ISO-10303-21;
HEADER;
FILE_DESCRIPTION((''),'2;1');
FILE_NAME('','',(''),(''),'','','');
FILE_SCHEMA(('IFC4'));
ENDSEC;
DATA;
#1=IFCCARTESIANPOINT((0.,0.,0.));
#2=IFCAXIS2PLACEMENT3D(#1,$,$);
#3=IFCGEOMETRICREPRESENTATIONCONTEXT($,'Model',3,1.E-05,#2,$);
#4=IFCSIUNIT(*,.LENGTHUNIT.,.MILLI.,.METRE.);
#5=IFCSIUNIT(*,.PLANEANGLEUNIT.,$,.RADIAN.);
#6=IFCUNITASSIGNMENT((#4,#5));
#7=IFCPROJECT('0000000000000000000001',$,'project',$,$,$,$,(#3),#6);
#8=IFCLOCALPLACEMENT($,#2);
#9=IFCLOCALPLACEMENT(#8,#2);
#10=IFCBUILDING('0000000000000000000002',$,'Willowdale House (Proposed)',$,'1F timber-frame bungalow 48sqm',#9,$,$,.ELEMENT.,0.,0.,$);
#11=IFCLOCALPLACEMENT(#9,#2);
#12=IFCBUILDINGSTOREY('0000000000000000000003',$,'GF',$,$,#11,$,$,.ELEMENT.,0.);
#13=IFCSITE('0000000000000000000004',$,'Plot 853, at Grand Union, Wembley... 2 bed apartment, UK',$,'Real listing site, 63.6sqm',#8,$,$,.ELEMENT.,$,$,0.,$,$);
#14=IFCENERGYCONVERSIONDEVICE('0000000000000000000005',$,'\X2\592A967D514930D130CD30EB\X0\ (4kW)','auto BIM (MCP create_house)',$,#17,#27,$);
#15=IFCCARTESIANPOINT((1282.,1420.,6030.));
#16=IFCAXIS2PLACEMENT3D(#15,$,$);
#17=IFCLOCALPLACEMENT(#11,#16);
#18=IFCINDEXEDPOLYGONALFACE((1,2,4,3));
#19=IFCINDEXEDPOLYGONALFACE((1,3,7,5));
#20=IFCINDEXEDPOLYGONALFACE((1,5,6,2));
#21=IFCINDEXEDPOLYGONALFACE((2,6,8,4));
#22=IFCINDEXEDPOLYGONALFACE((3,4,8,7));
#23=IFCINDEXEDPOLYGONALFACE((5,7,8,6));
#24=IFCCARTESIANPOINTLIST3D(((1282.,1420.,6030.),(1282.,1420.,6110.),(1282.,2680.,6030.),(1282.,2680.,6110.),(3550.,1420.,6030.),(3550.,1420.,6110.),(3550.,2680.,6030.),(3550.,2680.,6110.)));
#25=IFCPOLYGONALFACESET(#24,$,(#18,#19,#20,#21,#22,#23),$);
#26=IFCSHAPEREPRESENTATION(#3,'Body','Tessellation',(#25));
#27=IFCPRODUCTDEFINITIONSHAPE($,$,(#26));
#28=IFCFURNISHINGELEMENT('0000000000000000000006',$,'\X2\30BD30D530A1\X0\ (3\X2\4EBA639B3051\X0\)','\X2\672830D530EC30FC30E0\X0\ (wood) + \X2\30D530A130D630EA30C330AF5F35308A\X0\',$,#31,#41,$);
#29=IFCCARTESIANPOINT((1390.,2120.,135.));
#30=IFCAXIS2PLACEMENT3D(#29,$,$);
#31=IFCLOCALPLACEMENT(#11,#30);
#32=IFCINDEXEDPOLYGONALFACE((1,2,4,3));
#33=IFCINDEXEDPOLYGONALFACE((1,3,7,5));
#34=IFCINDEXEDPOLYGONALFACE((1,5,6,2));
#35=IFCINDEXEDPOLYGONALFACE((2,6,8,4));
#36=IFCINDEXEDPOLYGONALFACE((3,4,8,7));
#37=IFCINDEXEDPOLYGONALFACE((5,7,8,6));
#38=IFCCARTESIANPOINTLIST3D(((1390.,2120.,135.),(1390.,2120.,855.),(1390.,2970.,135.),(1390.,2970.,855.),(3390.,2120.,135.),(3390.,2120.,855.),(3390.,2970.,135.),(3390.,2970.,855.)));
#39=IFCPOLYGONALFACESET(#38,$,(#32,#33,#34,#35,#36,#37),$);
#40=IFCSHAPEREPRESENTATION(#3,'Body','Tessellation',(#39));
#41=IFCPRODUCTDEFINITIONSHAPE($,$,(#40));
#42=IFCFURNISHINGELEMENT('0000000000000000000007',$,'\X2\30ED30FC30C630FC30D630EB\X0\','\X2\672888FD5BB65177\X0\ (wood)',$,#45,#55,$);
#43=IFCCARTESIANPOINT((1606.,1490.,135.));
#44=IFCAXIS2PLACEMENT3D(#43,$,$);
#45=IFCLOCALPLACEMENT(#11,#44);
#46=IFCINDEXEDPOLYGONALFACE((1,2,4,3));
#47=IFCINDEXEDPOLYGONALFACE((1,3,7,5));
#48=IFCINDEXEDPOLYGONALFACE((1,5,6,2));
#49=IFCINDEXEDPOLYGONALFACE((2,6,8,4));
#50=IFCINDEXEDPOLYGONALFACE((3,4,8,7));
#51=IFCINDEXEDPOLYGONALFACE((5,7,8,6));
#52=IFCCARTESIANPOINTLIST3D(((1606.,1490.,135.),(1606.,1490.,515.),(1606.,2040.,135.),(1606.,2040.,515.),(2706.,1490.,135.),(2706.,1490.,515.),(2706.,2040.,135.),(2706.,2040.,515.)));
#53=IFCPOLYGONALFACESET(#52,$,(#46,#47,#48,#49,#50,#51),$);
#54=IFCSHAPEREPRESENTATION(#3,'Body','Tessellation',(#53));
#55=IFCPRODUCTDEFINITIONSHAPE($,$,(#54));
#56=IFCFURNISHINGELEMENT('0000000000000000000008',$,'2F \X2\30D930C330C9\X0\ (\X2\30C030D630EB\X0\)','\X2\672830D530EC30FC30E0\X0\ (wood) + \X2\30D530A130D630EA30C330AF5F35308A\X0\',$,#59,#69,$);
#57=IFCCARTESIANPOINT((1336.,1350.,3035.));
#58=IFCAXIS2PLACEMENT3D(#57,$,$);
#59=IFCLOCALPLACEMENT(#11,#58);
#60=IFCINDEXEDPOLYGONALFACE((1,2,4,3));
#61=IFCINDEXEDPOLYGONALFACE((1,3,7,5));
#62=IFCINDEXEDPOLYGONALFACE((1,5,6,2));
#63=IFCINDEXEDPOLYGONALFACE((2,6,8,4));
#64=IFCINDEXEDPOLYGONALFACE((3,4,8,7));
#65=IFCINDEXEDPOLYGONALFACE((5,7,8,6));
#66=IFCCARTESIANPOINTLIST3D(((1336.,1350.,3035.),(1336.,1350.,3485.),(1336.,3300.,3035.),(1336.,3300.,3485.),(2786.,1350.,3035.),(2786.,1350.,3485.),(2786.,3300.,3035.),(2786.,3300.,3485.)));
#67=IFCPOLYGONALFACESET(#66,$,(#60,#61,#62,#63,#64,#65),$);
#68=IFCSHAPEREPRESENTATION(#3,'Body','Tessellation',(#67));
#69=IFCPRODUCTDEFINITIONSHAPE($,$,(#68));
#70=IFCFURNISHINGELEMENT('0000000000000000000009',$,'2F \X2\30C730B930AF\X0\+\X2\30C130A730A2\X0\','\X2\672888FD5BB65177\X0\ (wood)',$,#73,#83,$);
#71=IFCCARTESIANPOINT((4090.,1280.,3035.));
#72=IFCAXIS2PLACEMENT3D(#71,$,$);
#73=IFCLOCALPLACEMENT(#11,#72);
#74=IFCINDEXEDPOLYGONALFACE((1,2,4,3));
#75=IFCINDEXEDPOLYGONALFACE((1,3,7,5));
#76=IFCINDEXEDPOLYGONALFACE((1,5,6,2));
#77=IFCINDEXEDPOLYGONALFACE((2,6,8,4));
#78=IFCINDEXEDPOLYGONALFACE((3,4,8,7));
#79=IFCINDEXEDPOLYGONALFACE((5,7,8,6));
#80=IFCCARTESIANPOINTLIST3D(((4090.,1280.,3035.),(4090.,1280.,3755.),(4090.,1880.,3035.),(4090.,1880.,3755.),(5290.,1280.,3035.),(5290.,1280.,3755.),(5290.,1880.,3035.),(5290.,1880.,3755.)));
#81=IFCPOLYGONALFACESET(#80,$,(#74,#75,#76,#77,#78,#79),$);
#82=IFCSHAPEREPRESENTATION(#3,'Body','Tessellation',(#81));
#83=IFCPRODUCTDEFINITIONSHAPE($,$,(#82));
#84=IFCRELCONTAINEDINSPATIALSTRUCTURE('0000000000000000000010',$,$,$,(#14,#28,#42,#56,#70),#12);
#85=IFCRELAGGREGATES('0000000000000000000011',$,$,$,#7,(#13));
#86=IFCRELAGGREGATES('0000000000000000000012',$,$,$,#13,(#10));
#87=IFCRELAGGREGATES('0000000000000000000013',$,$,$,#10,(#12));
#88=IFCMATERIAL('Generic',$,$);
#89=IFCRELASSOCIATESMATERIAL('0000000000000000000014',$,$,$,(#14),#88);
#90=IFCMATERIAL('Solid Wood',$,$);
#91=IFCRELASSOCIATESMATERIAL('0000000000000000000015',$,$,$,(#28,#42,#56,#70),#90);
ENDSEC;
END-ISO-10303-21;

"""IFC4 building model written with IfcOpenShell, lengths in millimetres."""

from ifc_helpers import new_model, si_unit, frame, frame_2d, origin, place, context, project, spatial, rectangle, extrude, material, element, save


model = new_model("IFC4")

# Units and contexts
model_context = context("Model", 3, precision=1e-05, world=origin())
ifc_project = project(units=[si_unit("LENGTHUNIT", "METRE", prefix="MILLI"), si_unit("PLANEANGLEUNIT", "RADIAN")], contexts=[model_context])

# Site, building, storey
site_placement = place(None, origin())
site = spatial("IfcSite", under=ifc_project, at=site_placement, Name="Plot 853, at Grand Union, Wembley... 2 bed apartment, UK", ObjectType="Real listing site, 63.6sqm", CompositionType="ELEMENT", RefElevation=0.0)
building_placement = place(site_placement, origin())
building = spatial("IfcBuilding", under=site, at=building_placement, Name="Willowdale House (Proposed)", ObjectType="1F timber-frame bungalow 48sqm", CompositionType="ELEMENT", ElevationOfRefHeight=0.0, ElevationOfTerrain=0.0)
storey_placement = place(building_placement, origin())
storey = spatial("IfcBuildingStorey", under=building, at=storey_placement, Name="GF", CompositionType="ELEMENT", Elevation=0.0)

# Shared definitions
ifc_material_1 = material(Name="Solid Wood")

# Shared definitions
ifc_material_2 = material(Name="Generic")

# Energy conversion device
energy_conversion_device_placement = place(storey_placement, frame((1282.0, 1420.0, 6030.0)))
element("IfcEnergyConversionDevice", 1, at=energy_conversion_device_placement, inside=storey, material=ifc_material_2, Name="太陽光パネル (4kW)", Description="auto BIM (MCP create_house)", context=model_context, shape_type="SweptSolid", body=[
    extrude(rectangle(XDim=2268.0, YDim=1260.0, at=frame_2d((1134.0, 630.0))), frame((1282.0, 1420.0, 6030.0)), (0.0, 0.0, 1.0), 80.0),
])

# Furnishing elements
furnishing_1_placement = place(storey_placement, frame((1390.0, 2120.0, 135.0)))
element("IfcFurnishingElement", 2, at=furnishing_1_placement, inside=storey, material=ifc_material_1, Name="ソファ (3人掛け)", Description="木フレーム (wood) + ファブリック張り", context=model_context, shape_type="SweptSolid", body=[
    extrude(rectangle(XDim=2000.0, YDim=850.0, at=frame_2d((1000.0, 425.0))), frame((1390.0, 2120.0, 135.0)), (0.0, 0.0, 1.0), 720.0),
])
furnishing_2_placement = place(storey_placement, frame((1606.0, 1490.0, 135.0)))
element("IfcFurnishingElement", 3, at=furnishing_2_placement, inside=storey, material=ifc_material_1, Name="ローテーブル", Description="木製家具 (wood)", context=model_context, shape_type="SweptSolid", body=[
    extrude(rectangle(XDim=1100.0, YDim=550.0, at=frame_2d((550.0, 275.0))), frame((1606.0, 1490.0, 135.0)), (0.0, 0.0, 1.0), 380.0),
])
furnishing_3_placement = place(storey_placement, frame((1336.0, 1350.0, 3035.0)))
element("IfcFurnishingElement", 4, at=furnishing_3_placement, inside=storey, material=ifc_material_1, Name="2F ベッド (ダブル)", Description="木フレーム (wood) + ファブリック張り", context=model_context, shape_type="SweptSolid", body=[
    extrude(rectangle(XDim=1450.0, YDim=1950.0, at=frame_2d((725.0, 975.0))), frame((1336.0, 1350.0, 3035.0)), (0.0, 0.0, 1.0), 450.0),
])
furnishing_4_placement = place(storey_placement, frame((4090.0, 1280.0, 3035.0)))
element("IfcFurnishingElement", 5, at=furnishing_4_placement, inside=storey, material=ifc_material_1, Name="2F デスク+チェア", Description="木製家具 (wood)", context=model_context, shape_type="SweptSolid", body=[
    extrude(rectangle(XDim=1200.0, YDim=600.0, at=frame_2d((600.0, 300.0))), frame((4090.0, 1280.0, 3035.0)), (0.0, 0.0, 1.0), 720.0),
])

save(model, "model.ifc")
